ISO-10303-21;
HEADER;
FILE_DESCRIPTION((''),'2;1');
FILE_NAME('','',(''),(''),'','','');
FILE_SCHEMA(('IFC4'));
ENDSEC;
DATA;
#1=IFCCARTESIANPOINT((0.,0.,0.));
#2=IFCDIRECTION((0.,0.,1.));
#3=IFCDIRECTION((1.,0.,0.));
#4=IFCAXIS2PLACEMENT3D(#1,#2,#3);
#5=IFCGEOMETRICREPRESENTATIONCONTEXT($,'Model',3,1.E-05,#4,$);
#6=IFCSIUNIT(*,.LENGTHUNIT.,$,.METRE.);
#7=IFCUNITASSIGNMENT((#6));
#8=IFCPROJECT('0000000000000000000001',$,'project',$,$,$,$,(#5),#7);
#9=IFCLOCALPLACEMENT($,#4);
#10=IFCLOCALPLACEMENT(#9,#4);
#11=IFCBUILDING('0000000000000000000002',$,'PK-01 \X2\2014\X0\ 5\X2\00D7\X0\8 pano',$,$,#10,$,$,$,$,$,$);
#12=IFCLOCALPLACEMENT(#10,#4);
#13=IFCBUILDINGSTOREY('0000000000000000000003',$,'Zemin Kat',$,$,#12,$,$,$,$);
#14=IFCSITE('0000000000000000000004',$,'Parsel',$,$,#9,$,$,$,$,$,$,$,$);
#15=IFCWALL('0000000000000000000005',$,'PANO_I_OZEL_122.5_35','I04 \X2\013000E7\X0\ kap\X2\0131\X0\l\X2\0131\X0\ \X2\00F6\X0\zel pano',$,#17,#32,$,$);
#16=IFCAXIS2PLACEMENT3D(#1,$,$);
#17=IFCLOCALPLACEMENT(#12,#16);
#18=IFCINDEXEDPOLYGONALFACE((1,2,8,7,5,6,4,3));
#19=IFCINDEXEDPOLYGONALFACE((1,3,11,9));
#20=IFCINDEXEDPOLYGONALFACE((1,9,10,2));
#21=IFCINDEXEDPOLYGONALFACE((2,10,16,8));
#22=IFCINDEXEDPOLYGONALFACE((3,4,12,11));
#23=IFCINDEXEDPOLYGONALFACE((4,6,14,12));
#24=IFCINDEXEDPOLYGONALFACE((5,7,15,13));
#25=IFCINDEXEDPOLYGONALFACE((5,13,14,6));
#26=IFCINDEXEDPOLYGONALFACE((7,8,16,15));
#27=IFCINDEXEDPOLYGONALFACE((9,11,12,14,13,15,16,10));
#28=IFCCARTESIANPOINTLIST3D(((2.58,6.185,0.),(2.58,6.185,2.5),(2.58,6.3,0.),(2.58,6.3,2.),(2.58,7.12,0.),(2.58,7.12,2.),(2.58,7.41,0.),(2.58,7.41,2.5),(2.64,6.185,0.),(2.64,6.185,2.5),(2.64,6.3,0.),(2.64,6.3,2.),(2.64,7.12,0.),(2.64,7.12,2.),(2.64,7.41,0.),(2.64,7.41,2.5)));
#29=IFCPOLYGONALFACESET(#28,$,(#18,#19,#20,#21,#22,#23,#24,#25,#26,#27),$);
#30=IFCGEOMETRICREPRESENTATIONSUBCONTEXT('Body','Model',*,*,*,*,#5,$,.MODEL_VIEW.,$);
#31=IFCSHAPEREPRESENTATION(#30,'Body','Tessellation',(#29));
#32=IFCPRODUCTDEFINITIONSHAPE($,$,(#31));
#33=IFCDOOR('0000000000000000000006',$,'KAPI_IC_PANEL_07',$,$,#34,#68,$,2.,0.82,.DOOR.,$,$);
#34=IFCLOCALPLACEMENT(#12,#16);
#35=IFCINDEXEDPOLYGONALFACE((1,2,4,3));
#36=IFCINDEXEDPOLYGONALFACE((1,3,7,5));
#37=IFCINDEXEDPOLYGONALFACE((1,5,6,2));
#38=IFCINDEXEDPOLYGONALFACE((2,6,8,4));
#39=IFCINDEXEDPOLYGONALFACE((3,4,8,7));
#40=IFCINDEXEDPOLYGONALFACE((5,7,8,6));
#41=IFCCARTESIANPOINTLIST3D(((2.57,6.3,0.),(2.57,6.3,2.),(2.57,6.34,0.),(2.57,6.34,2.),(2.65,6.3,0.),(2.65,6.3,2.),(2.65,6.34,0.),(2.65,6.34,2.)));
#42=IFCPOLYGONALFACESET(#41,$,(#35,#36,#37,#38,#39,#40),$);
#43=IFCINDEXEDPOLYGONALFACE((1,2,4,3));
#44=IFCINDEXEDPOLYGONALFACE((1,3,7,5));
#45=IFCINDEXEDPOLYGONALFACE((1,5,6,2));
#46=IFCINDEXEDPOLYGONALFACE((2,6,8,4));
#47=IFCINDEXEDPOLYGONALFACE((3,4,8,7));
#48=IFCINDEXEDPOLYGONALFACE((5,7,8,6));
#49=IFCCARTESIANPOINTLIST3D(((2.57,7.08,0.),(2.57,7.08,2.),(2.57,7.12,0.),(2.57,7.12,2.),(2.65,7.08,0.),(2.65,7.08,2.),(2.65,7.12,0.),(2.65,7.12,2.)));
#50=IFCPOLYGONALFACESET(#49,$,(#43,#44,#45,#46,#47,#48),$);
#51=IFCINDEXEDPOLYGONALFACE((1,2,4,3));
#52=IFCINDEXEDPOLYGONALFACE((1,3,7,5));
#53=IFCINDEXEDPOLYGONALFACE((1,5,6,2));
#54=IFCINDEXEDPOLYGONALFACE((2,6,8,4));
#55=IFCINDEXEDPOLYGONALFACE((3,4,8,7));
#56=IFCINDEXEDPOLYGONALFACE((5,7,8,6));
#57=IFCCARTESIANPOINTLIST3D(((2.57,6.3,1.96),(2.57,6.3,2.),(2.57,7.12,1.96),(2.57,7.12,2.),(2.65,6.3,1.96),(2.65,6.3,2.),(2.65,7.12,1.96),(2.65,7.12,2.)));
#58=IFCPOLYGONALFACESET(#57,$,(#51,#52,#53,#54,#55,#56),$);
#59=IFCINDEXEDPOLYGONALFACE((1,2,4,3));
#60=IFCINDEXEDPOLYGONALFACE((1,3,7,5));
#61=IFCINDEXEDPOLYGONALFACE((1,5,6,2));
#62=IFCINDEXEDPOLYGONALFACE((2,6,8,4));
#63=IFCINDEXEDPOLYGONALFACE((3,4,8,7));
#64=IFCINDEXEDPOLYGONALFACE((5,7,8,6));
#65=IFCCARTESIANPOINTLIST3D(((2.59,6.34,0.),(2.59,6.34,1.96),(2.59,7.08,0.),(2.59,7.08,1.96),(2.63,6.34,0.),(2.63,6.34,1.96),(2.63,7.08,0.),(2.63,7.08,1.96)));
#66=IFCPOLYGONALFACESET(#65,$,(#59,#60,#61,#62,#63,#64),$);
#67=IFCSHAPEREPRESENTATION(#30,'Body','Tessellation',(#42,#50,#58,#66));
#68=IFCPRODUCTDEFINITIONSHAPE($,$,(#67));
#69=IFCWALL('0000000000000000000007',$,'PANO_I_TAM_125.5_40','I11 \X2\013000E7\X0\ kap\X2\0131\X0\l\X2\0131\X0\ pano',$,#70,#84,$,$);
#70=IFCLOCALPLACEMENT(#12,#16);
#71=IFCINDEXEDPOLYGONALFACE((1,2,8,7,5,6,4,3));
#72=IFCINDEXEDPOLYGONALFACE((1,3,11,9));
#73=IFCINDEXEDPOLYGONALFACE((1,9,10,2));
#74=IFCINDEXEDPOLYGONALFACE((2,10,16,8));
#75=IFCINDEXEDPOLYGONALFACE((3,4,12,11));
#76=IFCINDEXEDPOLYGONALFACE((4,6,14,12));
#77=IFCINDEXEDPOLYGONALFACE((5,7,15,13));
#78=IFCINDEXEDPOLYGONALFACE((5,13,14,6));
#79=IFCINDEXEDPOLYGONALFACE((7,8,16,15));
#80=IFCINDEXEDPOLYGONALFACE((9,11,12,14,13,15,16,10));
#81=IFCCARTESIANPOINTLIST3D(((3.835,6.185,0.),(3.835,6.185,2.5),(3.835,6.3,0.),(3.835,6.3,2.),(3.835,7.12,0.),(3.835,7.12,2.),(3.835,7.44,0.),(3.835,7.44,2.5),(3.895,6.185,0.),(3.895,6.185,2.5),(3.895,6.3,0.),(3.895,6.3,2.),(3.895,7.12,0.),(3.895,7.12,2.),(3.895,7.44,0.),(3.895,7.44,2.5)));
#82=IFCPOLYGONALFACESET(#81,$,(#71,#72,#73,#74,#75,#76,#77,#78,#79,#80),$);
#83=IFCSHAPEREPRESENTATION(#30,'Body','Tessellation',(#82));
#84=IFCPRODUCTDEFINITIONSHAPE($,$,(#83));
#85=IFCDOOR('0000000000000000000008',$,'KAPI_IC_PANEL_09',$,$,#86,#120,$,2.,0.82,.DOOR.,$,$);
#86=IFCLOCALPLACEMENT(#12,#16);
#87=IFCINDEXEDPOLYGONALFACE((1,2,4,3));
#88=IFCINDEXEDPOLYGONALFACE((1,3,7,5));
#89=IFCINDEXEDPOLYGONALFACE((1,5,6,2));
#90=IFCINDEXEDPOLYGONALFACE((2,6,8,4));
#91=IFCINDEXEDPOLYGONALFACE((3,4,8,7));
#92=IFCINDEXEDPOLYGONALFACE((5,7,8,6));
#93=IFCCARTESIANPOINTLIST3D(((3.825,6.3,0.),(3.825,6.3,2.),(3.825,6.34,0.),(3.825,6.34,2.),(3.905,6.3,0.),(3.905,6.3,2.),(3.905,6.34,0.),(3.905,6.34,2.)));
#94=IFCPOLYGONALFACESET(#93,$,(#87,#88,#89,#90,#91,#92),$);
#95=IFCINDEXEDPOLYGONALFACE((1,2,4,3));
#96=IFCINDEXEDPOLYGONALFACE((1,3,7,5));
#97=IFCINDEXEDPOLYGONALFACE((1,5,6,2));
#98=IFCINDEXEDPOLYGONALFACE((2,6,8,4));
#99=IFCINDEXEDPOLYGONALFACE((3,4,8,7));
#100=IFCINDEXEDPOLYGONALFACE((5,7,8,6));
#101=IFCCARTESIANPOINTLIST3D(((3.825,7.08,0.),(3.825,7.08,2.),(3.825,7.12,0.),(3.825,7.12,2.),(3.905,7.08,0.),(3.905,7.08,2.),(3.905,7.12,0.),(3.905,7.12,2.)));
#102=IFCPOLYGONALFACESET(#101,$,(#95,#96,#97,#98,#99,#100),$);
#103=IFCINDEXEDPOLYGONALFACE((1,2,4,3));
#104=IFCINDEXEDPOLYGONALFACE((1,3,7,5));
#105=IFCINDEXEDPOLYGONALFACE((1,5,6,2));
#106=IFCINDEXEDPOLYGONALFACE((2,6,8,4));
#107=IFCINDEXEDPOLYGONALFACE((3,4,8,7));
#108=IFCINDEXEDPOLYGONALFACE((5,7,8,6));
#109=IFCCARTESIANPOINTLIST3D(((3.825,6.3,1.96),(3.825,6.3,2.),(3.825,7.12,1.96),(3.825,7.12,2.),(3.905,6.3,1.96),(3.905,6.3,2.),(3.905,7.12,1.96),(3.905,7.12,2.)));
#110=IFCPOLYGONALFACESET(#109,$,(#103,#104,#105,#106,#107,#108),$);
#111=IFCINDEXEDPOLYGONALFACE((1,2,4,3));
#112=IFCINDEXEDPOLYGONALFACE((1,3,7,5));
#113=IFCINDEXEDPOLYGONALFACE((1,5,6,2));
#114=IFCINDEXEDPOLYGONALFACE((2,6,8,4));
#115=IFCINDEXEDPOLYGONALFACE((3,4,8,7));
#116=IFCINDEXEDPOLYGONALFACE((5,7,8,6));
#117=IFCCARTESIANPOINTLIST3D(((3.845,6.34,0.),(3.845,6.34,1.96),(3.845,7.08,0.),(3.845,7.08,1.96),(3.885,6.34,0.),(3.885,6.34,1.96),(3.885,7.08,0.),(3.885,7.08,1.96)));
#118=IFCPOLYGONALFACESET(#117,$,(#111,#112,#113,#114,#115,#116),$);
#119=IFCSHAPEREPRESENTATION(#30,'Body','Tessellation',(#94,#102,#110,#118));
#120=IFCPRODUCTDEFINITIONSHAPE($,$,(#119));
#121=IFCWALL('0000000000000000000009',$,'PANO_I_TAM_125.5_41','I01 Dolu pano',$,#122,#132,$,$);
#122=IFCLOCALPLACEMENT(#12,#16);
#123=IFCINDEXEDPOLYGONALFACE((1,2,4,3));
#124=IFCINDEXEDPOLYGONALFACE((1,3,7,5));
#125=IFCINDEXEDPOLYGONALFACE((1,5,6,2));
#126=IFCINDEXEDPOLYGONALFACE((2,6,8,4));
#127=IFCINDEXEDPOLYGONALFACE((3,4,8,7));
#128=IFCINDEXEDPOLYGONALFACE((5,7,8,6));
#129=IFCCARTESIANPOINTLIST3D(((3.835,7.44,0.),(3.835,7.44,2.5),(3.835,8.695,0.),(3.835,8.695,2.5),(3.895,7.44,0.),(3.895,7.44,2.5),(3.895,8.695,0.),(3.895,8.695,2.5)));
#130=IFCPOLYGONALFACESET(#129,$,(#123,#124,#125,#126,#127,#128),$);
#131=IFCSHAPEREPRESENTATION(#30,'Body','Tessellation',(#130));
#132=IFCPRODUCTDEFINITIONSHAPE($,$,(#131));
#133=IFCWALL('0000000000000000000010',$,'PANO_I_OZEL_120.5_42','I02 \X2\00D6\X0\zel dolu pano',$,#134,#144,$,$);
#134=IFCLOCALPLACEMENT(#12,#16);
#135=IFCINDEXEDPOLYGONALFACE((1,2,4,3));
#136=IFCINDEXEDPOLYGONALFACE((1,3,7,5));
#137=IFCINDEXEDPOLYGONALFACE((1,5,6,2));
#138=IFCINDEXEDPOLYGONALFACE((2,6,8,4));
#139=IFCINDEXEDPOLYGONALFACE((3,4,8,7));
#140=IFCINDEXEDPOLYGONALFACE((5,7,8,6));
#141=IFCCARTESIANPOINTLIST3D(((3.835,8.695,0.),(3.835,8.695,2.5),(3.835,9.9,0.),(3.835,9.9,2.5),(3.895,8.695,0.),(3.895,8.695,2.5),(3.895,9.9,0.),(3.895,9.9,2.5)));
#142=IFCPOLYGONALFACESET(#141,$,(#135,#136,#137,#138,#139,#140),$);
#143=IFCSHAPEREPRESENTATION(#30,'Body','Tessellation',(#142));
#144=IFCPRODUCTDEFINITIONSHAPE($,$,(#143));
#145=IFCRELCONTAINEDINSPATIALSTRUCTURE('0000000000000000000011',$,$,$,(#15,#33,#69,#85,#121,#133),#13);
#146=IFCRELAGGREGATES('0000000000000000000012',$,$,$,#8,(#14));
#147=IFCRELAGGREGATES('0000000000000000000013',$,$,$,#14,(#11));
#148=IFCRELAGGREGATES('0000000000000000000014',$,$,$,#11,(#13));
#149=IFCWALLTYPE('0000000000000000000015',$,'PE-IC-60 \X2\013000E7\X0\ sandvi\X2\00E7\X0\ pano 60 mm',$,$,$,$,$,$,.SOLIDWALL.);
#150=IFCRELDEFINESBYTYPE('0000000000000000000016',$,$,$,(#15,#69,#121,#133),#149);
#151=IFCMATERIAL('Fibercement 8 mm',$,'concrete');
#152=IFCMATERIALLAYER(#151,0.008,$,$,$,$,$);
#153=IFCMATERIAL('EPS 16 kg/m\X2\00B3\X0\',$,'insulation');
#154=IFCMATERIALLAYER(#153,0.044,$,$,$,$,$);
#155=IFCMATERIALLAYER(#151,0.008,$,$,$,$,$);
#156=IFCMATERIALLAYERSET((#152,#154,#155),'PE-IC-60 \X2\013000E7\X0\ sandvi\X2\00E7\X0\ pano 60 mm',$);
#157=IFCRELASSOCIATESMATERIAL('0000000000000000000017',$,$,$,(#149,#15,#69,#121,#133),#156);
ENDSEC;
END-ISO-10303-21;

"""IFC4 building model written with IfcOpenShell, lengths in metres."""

from ifc_helpers import new_model, si_unit, frame, origin_with_axes, place, context, subcontext, project, spatial, line, indexed_curve, outline, extrude, material, layer, layer_set, layer_usage, type_object, element, fill, save


model = new_model("IFC4")

# Units and contexts
model_context = context("Model", 3, precision=1e-05, world=origin_with_axes())
body_context = subcontext(model_context, "Body", "Model", "MODEL_VIEW")
ifc_project = project(units=[si_unit("LENGTHUNIT", "METRE")], contexts=[model_context])

# Site, building, storey
site_placement = place(None, origin_with_axes())
site = spatial("IfcSite", under=ifc_project, at=site_placement, Name="Parsel")
building_placement = place(site_placement, origin_with_axes())
building = spatial("IfcBuilding", under=site, at=building_placement, Name="PK-01 — 5×8 pano")
storey_placement = place(building_placement, origin_with_axes())
storey = spatial("IfcBuildingStorey", under=building, at=storey_placement, Name="Zemin Kat")

# Shared definitions
ifc_material_1 = material(Name="Fibercement 8 mm", Category="concrete")
ifc_material_2 = material(Name="EPS 16 kg/m³", Category="insulation")

# Shared definitions
ifc_layer_1 = layer(ifc_material_1, 0.008)
ifc_layer_2 = layer(ifc_material_2, 0.044)
ifc_layer_3 = layer(ifc_material_1, 0.008)
ifc_layer_set_1 = layer_set([ifc_layer_1, ifc_layer_2, ifc_layer_3], Name="PE-IC-60 İç sandviç pano 60 mm")
wall_type_1 = type_object("IfcWallType", Name="PE-IC-60 İç sandviç pano 60 mm", PredefinedType="SOLIDWALL", material=ifc_layer_set_1)

# Walls, openings, doors
ifc_layer_usage_1 = layer_usage(ifc_layer_set_1, "AXIS2", "POSITIVE", 0.0)
wall_1_placement = place(storey_placement, frame((2.64, 6.185, 0.0), z_axis=(0.0, 0.0, 1.0), x_axis=(0.0, 1.0, 0.0)))
wall_1 = element("IfcWall", 1, at=wall_1_placement, inside=storey, type_object=wall_type_1, material=ifc_layer_usage_1, Name="PANO_I_OZEL_122.5_35", Description="I04 İç kapılı özel pano", context=body_context, shape_type="SweptSolid", body=[
    extrude(outline(indexed_curve([(0.0, 0.0), (1.225, 0.0), (1.225, 0.06), (0.0, 0.06)], segments=[line(1, 2, 3, 4, 1)])), origin_with_axes(), (0.0, 0.0, 1.0), 2.5),
])
opening_1_placement = place(wall_1_placement, origin_with_axes())
opening_1 = element("IfcOpeningElement", 2, at=opening_1_placement, cuts=wall_1, PredefinedType="OPENING", context=body_context, shape_type="SweptSolid", body=[
    extrude(outline(indexed_curve([(0.0, 0.0), (0.82, 0.0), (0.82, 0.1), (0.0, 0.1)], segments=[line(1, 2, 3, 4, 1)])), frame((0.115, -0.02, 0.0), z_axis=(0.0, 0.0, 1.0), x_axis=(1.0, 0.0, 0.0)), (0.0, 0.0, 1.0), 2.0),
])
door_1_placement = place(storey_placement, frame((2.64, 6.185, 0.0), z_axis=(0.0, 0.0, 1.0), x_axis=(0.0, 1.0, 0.0)))
door_1 = element("IfcDoor", 3, at=door_1_placement, inside=storey, Name="KAPI_IC_PANEL_07", OverallHeight=2.0, OverallWidth=0.82, PredefinedType="DOOR", context=body_context, shape_type="SweptSolid", body=[
    extrude(outline(indexed_curve([(0.0, 0.0), (0.04, 0.0), (0.04, 0.08), (0.0, 0.08)], segments=[line(1, 2, 3, 4, 1)])), frame((0.115, -0.01, 0.0), z_axis=(0.0, 0.0, 1.0), x_axis=(1.0, 0.0, 0.0)), (0.0, 0.0, 1.0), 2.0),
    extrude(outline(indexed_curve([(0.0, 0.0), (0.04, 0.0), (0.04, 0.08), (0.0, 0.08)], segments=[line(1, 2, 3, 4, 1)])), frame((0.895, -0.01, 0.0), z_axis=(0.0, 0.0, 1.0), x_axis=(1.0, 0.0, 0.0)), (0.0, 0.0, 1.0), 2.0),
    extrude(outline(indexed_curve([(0.0, 0.0), (0.82, 0.0), (0.82, 0.08), (0.0, 0.08)], segments=[line(1, 2, 3, 4, 1)])), frame((0.115, -0.01, 1.96), z_axis=(0.0, 0.0, 1.0), x_axis=(1.0, 0.0, 0.0)), (0.0, 0.0, 1.0), 0.04),
    extrude(outline(indexed_curve([(0.0, 0.0), (0.74, 0.0), (0.74, 0.04), (0.0, 0.04)], segments=[line(1, 2, 3, 4, 1)])), frame((0.155, 0.01, 0.0), z_axis=(0.0, 0.0, 1.0), x_axis=(1.0, 0.0, 0.0)), (0.0, 0.0, 1.0), 1.96),
])
fill(opening_1, door_1)
ifc_layer_usage_2 = layer_usage(ifc_layer_set_1, "AXIS2", "POSITIVE", 0.0)
wall_2_placement = place(storey_placement, frame((3.895, 6.185, 0.0), z_axis=(0.0, 0.0, 1.0), x_axis=(0.0, 1.0, 0.0)))
wall_2 = element("IfcWall", 4, at=wall_2_placement, inside=storey, type_object=wall_type_1, material=ifc_layer_usage_2, Name="PANO_I_TAM_125.5_40", Description="I11 İç kapılı pano", context=body_context, shape_type="SweptSolid", body=[
    extrude(outline(indexed_curve([(0.0, 0.0), (1.255, 0.0), (1.255, 0.06), (0.0, 0.06)], segments=[line(1, 2, 3, 4, 1)])), origin_with_axes(), (0.0, 0.0, 1.0), 2.5),
])
opening_2_placement = place(wall_2_placement, origin_with_axes())
opening_2 = element("IfcOpeningElement", 5, at=opening_2_placement, cuts=wall_2, PredefinedType="OPENING", context=body_context, shape_type="SweptSolid", body=[
    extrude(outline(indexed_curve([(0.0, 0.0), (0.82, 0.0), (0.82, 0.1), (0.0, 0.1)], segments=[line(1, 2, 3, 4, 1)])), frame((0.115, -0.02, 0.0), z_axis=(0.0, 0.0, 1.0), x_axis=(1.0, 0.0, 0.0)), (0.0, 0.0, 1.0), 2.0),
])
door_2_placement = place(storey_placement, frame((3.895, 6.185, 0.0), z_axis=(0.0, 0.0, 1.0), x_axis=(0.0, 1.0, 0.0)))
door_2 = element("IfcDoor", 6, at=door_2_placement, inside=storey, Name="KAPI_IC_PANEL_09", OverallHeight=2.0, OverallWidth=0.82, PredefinedType="DOOR", context=body_context, shape_type="SweptSolid", body=[
    extrude(outline(indexed_curve([(0.0, 0.0), (0.04, 0.0), (0.04, 0.08), (0.0, 0.08)], segments=[line(1, 2, 3, 4, 1)])), frame((0.115, -0.01, 0.0), z_axis=(0.0, 0.0, 1.0), x_axis=(1.0, 0.0, 0.0)), (0.0, 0.0, 1.0), 2.0),
    extrude(outline(indexed_curve([(0.0, 0.0), (0.04, 0.0), (0.04, 0.08), (0.0, 0.08)], segments=[line(1, 2, 3, 4, 1)])), frame((0.895, -0.01, 0.0), z_axis=(0.0, 0.0, 1.0), x_axis=(1.0, 0.0, 0.0)), (0.0, 0.0, 1.0), 2.0),
    extrude(outline(indexed_curve([(0.0, 0.0), (0.82, 0.0), (0.82, 0.08), (0.0, 0.08)], segments=[line(1, 2, 3, 4, 1)])), frame((0.115, -0.01, 1.96), z_axis=(0.0, 0.0, 1.0), x_axis=(1.0, 0.0, 0.0)), (0.0, 0.0, 1.0), 0.04),
    extrude(outline(indexed_curve([(0.0, 0.0), (0.74, 0.0), (0.74, 0.04), (0.0, 0.04)], segments=[line(1, 2, 3, 4, 1)])), frame((0.155, 0.01, 0.0), z_axis=(0.0, 0.0, 1.0), x_axis=(1.0, 0.0, 0.0)), (0.0, 0.0, 1.0), 1.96),
])
fill(opening_2, door_2)

# Walls
ifc_layer_usage_3 = layer_usage(ifc_layer_set_1, "AXIS2", "POSITIVE", 0.0)
wall_3_placement = place(storey_placement, frame((3.895, 7.44, 0.0), z_axis=(0.0, 0.0, 1.0), x_axis=(0.0, 1.0, 0.0)))
element("IfcWall", 7, at=wall_3_placement, inside=storey, type_object=wall_type_1, material=ifc_layer_usage_3, Name="PANO_I_TAM_125.5_41", Description="I01 Dolu pano", context=body_context, shape_type="SweptSolid", body=[
    extrude(outline(indexed_curve([(0.0, 0.0), (1.255, 0.0), (1.255, 0.06), (0.0, 0.06)], segments=[line(1, 2, 3, 4, 1)])), origin_with_axes(), (0.0, 0.0, 1.0), 2.5),
])
ifc_layer_usage_4 = layer_usage(ifc_layer_set_1, "AXIS2", "POSITIVE", 0.0)
wall_4_placement = place(storey_placement, frame((3.895, 8.695, 0.0), z_axis=(0.0, 0.0, 1.0), x_axis=(0.0, 1.0, 0.0)))
element("IfcWall", 8, at=wall_4_placement, inside=storey, type_object=wall_type_1, material=ifc_layer_usage_4, Name="PANO_I_OZEL_120.5_42", Description="I02 Özel dolu pano", context=body_context, shape_type="SweptSolid", body=[
    extrude(outline(indexed_curve([(0.0, 0.0), (1.205, 0.0), (1.205, 0.06), (0.0, 0.06)], segments=[line(1, 2, 3, 4, 1)])), origin_with_axes(), (0.0, 0.0, 1.0), 2.5),
])

save(model, "model.ifc")
